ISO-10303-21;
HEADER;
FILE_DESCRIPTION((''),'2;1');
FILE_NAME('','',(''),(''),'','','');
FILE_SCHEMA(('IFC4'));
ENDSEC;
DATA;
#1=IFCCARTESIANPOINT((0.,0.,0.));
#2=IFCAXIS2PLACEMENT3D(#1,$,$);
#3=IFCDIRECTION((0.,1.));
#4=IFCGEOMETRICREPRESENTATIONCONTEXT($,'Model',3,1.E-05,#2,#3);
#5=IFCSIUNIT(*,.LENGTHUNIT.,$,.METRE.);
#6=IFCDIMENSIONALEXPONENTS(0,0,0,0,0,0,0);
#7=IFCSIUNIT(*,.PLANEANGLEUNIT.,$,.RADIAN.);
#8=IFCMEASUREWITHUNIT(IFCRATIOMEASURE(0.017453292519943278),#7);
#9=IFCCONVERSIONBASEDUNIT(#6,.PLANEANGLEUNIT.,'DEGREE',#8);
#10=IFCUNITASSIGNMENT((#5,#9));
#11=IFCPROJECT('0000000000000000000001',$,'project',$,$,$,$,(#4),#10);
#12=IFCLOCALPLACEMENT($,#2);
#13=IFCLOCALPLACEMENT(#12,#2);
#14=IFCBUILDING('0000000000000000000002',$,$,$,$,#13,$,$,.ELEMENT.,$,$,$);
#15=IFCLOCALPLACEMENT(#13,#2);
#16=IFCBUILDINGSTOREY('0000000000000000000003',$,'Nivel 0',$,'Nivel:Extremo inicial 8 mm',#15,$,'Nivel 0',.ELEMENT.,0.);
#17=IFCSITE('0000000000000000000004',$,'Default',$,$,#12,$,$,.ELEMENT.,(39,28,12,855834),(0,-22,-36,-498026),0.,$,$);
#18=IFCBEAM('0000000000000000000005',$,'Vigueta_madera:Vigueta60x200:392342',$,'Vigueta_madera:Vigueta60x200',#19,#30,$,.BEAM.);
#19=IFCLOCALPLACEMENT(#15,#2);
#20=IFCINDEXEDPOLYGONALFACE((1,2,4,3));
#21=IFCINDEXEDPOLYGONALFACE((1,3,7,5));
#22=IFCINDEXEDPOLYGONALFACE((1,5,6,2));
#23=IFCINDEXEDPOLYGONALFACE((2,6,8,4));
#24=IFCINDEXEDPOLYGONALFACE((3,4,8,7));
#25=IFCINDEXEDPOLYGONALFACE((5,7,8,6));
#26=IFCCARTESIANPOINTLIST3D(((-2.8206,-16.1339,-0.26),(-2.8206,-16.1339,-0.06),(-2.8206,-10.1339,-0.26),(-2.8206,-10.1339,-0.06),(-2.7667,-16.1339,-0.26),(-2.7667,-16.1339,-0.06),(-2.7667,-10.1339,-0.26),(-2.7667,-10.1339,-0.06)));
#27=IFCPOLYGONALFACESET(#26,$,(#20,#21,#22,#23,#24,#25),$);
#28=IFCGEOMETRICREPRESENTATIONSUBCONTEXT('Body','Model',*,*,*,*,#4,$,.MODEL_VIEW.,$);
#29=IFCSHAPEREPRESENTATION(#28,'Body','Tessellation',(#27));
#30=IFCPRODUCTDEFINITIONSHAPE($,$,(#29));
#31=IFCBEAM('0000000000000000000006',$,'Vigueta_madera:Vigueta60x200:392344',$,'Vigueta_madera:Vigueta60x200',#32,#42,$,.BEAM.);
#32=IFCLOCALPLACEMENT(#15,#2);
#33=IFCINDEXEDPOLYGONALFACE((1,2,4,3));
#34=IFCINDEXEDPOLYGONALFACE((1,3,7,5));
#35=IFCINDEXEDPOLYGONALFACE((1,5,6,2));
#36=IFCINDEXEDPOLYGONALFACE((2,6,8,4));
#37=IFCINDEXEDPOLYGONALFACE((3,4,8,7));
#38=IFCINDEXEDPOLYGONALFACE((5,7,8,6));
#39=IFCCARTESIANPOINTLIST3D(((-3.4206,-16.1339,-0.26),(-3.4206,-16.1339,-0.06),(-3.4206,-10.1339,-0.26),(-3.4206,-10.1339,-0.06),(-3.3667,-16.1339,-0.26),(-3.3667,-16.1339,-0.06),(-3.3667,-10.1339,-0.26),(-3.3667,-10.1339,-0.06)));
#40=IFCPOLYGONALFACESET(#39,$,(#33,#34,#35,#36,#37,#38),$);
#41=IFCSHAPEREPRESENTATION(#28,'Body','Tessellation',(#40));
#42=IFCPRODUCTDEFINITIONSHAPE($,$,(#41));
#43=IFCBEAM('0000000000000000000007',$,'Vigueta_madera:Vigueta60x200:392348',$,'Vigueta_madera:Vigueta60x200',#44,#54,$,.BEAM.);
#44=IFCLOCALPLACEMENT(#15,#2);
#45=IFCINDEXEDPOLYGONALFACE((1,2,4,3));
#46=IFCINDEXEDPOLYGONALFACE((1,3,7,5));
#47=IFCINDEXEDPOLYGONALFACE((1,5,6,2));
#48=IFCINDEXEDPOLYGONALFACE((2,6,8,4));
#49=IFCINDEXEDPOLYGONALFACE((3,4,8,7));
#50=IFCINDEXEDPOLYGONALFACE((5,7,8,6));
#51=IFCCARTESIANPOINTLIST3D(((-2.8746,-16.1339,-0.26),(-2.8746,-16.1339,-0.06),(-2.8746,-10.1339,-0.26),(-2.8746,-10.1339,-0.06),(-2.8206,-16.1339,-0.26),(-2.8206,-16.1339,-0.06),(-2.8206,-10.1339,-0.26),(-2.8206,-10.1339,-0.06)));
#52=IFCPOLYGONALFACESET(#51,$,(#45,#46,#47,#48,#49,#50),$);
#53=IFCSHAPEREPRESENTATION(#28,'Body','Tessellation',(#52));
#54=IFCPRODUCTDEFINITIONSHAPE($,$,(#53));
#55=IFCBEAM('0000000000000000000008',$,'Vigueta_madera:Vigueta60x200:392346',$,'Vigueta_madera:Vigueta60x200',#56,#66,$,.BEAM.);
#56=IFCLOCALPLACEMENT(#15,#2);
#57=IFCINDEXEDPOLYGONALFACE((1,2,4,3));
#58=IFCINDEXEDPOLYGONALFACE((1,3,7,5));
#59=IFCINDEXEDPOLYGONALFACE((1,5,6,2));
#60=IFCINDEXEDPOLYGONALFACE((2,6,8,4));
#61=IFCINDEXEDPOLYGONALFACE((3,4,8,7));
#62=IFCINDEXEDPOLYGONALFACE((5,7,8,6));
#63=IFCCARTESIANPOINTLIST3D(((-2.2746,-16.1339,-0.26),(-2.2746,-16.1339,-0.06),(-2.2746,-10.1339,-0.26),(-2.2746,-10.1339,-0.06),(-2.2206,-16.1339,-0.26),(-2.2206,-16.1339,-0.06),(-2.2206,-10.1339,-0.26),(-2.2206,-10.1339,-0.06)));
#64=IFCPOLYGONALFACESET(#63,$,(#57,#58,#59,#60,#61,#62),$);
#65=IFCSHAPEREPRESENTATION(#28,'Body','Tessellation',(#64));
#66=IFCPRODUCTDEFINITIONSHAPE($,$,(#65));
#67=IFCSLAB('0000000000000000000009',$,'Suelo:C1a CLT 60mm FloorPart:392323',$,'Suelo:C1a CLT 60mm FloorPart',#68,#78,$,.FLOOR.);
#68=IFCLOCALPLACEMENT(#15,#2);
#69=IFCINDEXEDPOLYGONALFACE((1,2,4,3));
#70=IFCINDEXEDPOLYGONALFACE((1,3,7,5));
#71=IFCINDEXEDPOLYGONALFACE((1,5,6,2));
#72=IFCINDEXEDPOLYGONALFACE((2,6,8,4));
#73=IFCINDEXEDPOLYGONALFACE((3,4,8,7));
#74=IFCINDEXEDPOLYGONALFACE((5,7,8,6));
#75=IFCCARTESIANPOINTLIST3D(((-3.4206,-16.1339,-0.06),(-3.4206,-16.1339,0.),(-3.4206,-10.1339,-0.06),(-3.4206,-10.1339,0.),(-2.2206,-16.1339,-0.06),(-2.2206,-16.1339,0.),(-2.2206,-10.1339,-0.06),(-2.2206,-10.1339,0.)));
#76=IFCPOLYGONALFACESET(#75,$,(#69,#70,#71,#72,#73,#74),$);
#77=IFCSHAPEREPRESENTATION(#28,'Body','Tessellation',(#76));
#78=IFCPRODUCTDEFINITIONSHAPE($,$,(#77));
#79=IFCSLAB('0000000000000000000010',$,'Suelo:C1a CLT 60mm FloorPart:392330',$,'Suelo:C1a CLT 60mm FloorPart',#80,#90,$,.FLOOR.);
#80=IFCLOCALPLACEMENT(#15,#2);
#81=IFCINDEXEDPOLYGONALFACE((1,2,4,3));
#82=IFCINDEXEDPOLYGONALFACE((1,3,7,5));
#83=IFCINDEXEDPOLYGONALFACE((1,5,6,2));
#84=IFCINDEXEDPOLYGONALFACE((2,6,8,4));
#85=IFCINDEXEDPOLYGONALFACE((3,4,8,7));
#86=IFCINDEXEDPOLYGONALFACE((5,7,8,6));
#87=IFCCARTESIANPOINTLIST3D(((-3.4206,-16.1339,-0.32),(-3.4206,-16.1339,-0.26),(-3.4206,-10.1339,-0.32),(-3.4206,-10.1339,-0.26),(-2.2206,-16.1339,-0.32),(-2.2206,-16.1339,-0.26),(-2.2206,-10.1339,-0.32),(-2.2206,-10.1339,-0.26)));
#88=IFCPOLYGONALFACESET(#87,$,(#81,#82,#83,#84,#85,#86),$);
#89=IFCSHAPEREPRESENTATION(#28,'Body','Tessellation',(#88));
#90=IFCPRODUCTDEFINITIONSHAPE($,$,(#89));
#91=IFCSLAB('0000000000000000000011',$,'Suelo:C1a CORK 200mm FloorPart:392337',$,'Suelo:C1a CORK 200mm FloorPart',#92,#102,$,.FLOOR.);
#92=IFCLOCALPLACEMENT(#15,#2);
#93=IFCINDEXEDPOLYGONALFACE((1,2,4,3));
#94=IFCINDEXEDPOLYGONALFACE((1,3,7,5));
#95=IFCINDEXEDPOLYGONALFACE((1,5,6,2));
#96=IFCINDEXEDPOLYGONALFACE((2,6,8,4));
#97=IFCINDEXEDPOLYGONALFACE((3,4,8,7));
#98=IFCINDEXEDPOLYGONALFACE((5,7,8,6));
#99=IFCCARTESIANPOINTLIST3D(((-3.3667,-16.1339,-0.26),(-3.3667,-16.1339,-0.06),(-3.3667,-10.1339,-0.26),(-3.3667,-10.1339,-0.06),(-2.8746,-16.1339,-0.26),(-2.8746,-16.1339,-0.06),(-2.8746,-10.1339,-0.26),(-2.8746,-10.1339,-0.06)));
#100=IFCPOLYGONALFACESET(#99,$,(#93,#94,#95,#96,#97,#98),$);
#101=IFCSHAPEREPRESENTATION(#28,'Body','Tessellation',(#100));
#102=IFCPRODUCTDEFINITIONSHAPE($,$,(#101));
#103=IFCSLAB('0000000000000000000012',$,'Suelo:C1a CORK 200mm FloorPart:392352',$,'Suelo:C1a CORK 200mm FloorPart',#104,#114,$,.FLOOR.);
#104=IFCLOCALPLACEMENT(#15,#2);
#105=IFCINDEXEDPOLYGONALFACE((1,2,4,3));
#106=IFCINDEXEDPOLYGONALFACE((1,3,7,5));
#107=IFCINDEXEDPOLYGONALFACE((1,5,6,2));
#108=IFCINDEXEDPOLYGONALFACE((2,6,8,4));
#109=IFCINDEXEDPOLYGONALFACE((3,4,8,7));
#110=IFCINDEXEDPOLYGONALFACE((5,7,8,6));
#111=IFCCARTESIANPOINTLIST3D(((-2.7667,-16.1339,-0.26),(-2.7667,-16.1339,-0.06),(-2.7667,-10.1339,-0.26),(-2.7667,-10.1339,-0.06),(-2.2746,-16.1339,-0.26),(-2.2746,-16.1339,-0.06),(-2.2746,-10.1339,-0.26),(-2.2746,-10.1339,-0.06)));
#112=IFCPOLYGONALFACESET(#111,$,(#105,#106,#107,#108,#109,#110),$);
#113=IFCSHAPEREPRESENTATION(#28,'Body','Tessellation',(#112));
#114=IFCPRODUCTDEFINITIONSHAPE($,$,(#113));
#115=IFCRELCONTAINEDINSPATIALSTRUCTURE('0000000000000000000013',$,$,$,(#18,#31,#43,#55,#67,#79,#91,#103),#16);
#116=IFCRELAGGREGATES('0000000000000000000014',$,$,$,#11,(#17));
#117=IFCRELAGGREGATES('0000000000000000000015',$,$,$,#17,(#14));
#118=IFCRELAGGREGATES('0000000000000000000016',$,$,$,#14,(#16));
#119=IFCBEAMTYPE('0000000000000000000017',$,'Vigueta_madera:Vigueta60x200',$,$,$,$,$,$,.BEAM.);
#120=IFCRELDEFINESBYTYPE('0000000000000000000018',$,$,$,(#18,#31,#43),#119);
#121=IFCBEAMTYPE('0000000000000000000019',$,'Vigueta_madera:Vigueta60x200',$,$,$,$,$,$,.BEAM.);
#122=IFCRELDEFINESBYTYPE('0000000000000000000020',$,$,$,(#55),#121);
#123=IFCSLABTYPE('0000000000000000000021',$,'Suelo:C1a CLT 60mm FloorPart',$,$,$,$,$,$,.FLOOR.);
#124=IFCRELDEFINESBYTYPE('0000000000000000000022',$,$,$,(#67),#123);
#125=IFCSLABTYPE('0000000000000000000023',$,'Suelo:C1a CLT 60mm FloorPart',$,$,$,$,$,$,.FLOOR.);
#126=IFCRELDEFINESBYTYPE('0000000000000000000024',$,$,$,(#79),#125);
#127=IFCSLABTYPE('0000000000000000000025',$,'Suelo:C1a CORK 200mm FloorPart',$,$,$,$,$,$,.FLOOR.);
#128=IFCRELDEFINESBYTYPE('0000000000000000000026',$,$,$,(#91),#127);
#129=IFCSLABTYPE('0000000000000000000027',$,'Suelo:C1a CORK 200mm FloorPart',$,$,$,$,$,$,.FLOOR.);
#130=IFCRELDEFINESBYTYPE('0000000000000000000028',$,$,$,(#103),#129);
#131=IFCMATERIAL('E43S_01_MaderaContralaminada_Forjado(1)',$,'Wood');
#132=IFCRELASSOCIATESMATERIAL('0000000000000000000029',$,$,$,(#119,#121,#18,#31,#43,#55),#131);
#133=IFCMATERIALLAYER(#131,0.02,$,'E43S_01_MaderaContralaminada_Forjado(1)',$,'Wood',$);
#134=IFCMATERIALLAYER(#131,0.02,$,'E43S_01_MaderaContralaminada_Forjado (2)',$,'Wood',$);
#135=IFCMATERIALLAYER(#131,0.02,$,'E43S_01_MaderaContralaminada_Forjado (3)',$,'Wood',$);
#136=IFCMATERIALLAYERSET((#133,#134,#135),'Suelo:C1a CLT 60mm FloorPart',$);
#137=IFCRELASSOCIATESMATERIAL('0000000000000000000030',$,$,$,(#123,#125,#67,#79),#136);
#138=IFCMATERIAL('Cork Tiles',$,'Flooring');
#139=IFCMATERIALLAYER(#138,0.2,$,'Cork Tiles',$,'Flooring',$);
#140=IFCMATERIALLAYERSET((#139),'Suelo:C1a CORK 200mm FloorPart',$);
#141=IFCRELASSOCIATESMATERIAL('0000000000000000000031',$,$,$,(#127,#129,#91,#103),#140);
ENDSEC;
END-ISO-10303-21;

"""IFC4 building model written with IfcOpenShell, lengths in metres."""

from ifc_helpers import new_model, entity, si_unit, converted_unit, direction, frame, frame_2d, origin, origin_2d_with_axis, place, context, subcontext, project, spatial, polyline, segment, composite_curve, rectangle, outline, extrude, source, transform, mapped, material, layer, layer_set, layer_usage, material_profile, profile_set, profile_usage, type_object, type_shapes, element, save


model = new_model("IFC4")

# Units and contexts
model_context = context("Model", 3, precision=1e-05, world=origin(), true_north=direction((0.0, 1.0)))
body_context = subcontext(model_context, "Body", "Model", "MODEL_VIEW")
ifc_project = project(units=[si_unit("LENGTHUNIT", "METRE"), converted_unit("PLANEANGLEUNIT", "DEGREE", entity("IfcRatioMeasure", 0.017453292519943278), si_unit("PLANEANGLEUNIT", "RADIAN"), dimensions=[0, 0, 0, 0, 0, 0, 0])], contexts=[model_context])

# Site, building, storey
site_placement = place(None, origin())
site = spatial("IfcSite", under=ifc_project, at=site_placement, Name="Default", CompositionType="ELEMENT", RefLatitude=(39, 28, 12, 855834), RefLongitude=(0, -22, -36, -498026), RefElevation=0.0)
building_placement = place(site_placement, origin())
building = spatial("IfcBuilding", under=site, at=building_placement, CompositionType="ELEMENT")
storey_placement = place(building_placement, origin())
storey = spatial("IfcBuildingStorey", under=building, at=storey_placement, Name="Nivel 0", ObjectType="Nivel:Extremo inicial 8 mm", LongName="Nivel 0", CompositionType="ELEMENT", Elevation=0.0)

# Beams
ifc_material_1 = material(Name="E43S_01_MaderaContralaminada_Forjado(1)", Category="Wood")
ifc_material_profile_1 = material_profile(ifc_material_1, outline(composite_curve([segment(polyline([(-0.027, -0.1, 0.0), (-0.027, 0.1, 0.0)]), True, "CONTINUOUS"), segment(polyline([(-0.027, 0.1, 0.0), (0.027, 0.1, 0.0)]), True, "CONTINUOUS"), segment(polyline([(0.027, 0.1, 0.0), (0.027, -0.1, 0.0)]), True, "CONTINUOUS"), segment(polyline([(0.027, -0.1, 0.0), (-0.027, -0.1, 0.0)]), True, "CONTINUOUS")], self_intersect=False), kind="CURVE"), Name="Vigueta60x200")
ifc_material_profile_2 = material_profile(ifc_material_1, outline(composite_curve([segment(polyline([(3.0, 0.027, 0.1), (3.0, 0.027, -0.1)]), True, "CONTINUOUS"), segment(polyline([(3.0, 0.027, -0.1), (-3.0, 0.027, -0.1)]), True, "CONTINUOUS"), segment(polyline([(-3.0, 0.027, -0.1), (-3.0, 0.027, 0.1)]), True, "CONTINUOUS"), segment(polyline([(-3.0, 0.027, 0.1), (3.0, 0.027, 0.1)]), True, "CONTINUOUS")], self_intersect=False), kind="CURVE"), Name="Vigueta60x200")
ifc_profile_set = profile_set([ifc_material_profile_1, ifc_material_profile_2], Name="Vigueta60x200")
ifc_profile_usage_1 = profile_usage(ifc_profile_set, cardinal=8)
beam_type_1 = type_object("IfcBeamType", Name="Vigueta_madera:Vigueta60x200", PredefinedType="BEAM", material=ifc_profile_set)
shared_shape_1 = source(origin(), body_context, "Body", "SweptSolid", [
    extrude(rectangle(XDim=0.2, YDim=0.054, at=origin_2d_with_axis()), frame((-3.0, 0.0, 0.0), z_axis=(1.0, 0.0, 0.0), x_axis=(0.0, 0.0, -1.0)), (0.0, 0.0, 1.0), 6.0),
])
type_shapes(beam_type_1, [shared_shape_1])
beam_1_placement = place(storey_placement, frame((-2.7936, -13.1339, -0.16), z_axis=(0.0, 0.0, 1.0), x_axis=(0.0, 1.0, 0.0)))
element("IfcBeam", 1, at=beam_1_placement, inside=storey, type_object=beam_type_1, material=ifc_profile_usage_1, Name="Vigueta_madera:Vigueta60x200:392342", ObjectType="Vigueta_madera:Vigueta60x200", PredefinedType="BEAM", context=body_context, shape_type="MappedRepresentation", body=[
    mapped(shared_shape_1, transform((0.0, 0.0, 0.0), scale=1.0)),
])
ifc_profile_usage_2 = profile_usage(ifc_profile_set, cardinal=8)
beam_2_placement = place(storey_placement, frame((-3.3936, -13.1339, -0.16), z_axis=(0.0, 0.0, 1.0), x_axis=(0.0, 1.0, 0.0)))
element("IfcBeam", 2, at=beam_2_placement, inside=storey, type_object=beam_type_1, material=ifc_profile_usage_2, Name="Vigueta_madera:Vigueta60x200:392344", ObjectType="Vigueta_madera:Vigueta60x200", PredefinedType="BEAM", context=body_context, shape_type="MappedRepresentation", body=[
    mapped(shared_shape_1, transform((0.0, 0.0, 0.0), scale=1.0)),
])
ifc_profile_usage_3 = profile_usage(ifc_profile_set, cardinal=8)
beam_3_placement = place(storey_placement, frame((-2.8476, -13.1339, -0.16), z_axis=(0.0, 0.0, 1.0), x_axis=(0.0, 1.0, 0.0)))
element("IfcBeam", 3, at=beam_3_placement, inside=storey, type_object=beam_type_1, material=ifc_profile_usage_3, Name="Vigueta_madera:Vigueta60x200:392348", ObjectType="Vigueta_madera:Vigueta60x200", PredefinedType="BEAM", context=body_context, shape_type="MappedRepresentation", body=[
    mapped(shared_shape_1, transform((0.0, 0.0, 0.0), scale=1.0)),
])
ifc_profile_usage_4 = profile_usage(ifc_profile_set, cardinal=8)
beam_type_2 = type_object("IfcBeamType", Name="Vigueta_madera:Vigueta60x200", PredefinedType="BEAM", material=ifc_profile_set)
shared_shape_2 = source(origin(), body_context, "Body", "SweptSolid", [
    extrude(rectangle(XDim=0.2, YDim=0.054, at=origin_2d_with_axis()), frame((-3.06, 0.0, 0.0), z_axis=(1.0, 0.0, 0.0), x_axis=(0.0, 0.0, -1.0)), (0.0, 0.0, 1.0), 6.0),
])
type_shapes(beam_type_2, [shared_shape_2])
beam_4_placement = place(storey_placement, frame((-2.2476, -13.0739, -0.16), z_axis=(0.0, 0.0, 1.0), x_axis=(0.0, 1.0, 0.0)))
element("IfcBeam", 4, at=beam_4_placement, inside=storey, type_object=beam_type_2, material=ifc_profile_usage_4, Name="Vigueta_madera:Vigueta60x200:392346", ObjectType="Vigueta_madera:Vigueta60x200", PredefinedType="BEAM", context=body_context, shape_type="MappedRepresentation", body=[
    mapped(shared_shape_2, transform((0.0, 0.0, 0.0), scale=1.0)),
])

# Slabs
ifc_layer_1 = layer(ifc_material_1, 0.02, Name="E43S_01_MaderaContralaminada_Forjado(1)", Category="Wood")
ifc_layer_2 = layer(ifc_material_1, 0.02, Name="E43S_01_MaderaContralaminada_Forjado (2)", Category="Wood")
ifc_layer_3 = layer(ifc_material_1, 0.02, Name="E43S_01_MaderaContralaminada_Forjado (3)", Category="Wood")
ifc_layer_set_1 = layer_set([ifc_layer_1, ifc_layer_2, ifc_layer_3], Name="Suelo:C1a CLT 60mm FloorPart")
ifc_layer_usage_1 = layer_usage(ifc_layer_set_1, "AXIS3", "POSITIVE", 0.0)
slab_type_1 = type_object("IfcSlabType", Name="Suelo:C1a CLT 60mm FloorPart", PredefinedType="FLOOR", material=ifc_layer_set_1)
slab_1_placement = place(storey_placement, origin())
element("IfcSlab", 5, at=slab_1_placement, inside=storey, type_object=slab_type_1, material=ifc_layer_usage_1, Name="Suelo:C1a CLT 60mm FloorPart:392323", ObjectType="Suelo:C1a CLT 60mm FloorPart", PredefinedType="FLOOR", context=body_context, shape_type="SweptSolid", body=[
    extrude(rectangle(XDim=6.0, YDim=1.2, at=frame_2d((0.0, 0.0), x_axis=(1.0, 0.0))), frame((-2.8206, -13.1339, 0.0), z_axis=(0.0, 0.0, -1.0), x_axis=(0.0, 1.0, 0.0)), (0.0, 0.0, 1.0), 0.06),
])
ifc_layer_usage_2 = layer_usage(ifc_layer_set_1, "AXIS3", "POSITIVE", 0.0)
slab_type_2 = type_object("IfcSlabType", Name="Suelo:C1a CLT 60mm FloorPart", PredefinedType="FLOOR", material=ifc_layer_set_1)
slab_2_placement = place(storey_placement, origin())
element("IfcSlab", 6, at=slab_2_placement, inside=storey, type_object=slab_type_2, material=ifc_layer_usage_2, Name="Suelo:C1a CLT 60mm FloorPart:392330", ObjectType="Suelo:C1a CLT 60mm FloorPart", PredefinedType="FLOOR", context=body_context, shape_type="SweptSolid", body=[
    extrude(rectangle(XDim=6.0, YDim=1.2, at=frame_2d((0.0, 0.0), x_axis=(1.0, 0.0))), frame((-2.8206, -13.1339, -0.26), z_axis=(0.0, 0.0, -1.0), x_axis=(0.0, 1.0, 0.0)), (0.0, 0.0, 1.0), 0.06),
])
ifc_material_2 = material(Name="Cork Tiles", Category="Flooring")
ifc_layer_4 = layer(ifc_material_2, 0.2, Name="Cork Tiles", Category="Flooring")
ifc_layer_set_2 = layer_set([ifc_layer_4], Name="Suelo:C1a CORK 200mm FloorPart")
ifc_layer_usage_3 = layer_usage(ifc_layer_set_2, "AXIS3", "POSITIVE", 0.0)
slab_type_3 = type_object("IfcSlabType", Name="Suelo:C1a CORK 200mm FloorPart", PredefinedType="FLOOR", material=ifc_layer_set_2)
slab_3_placement = place(storey_placement, origin())
element("IfcSlab", 7, at=slab_3_placement, inside=storey, type_object=slab_type_3, material=ifc_layer_usage_3, Name="Suelo:C1a CORK 200mm FloorPart:392337", ObjectType="Suelo:C1a CORK 200mm FloorPart", PredefinedType="FLOOR", context=body_context, shape_type="SweptSolid", body=[
    extrude(rectangle(XDim=6.0, YDim=0.492, at=frame_2d((0.0, 0.0), x_axis=(1.0, 0.0))), frame((-3.1206, -13.1339, -0.06), z_axis=(0.0, 0.0, -1.0), x_axis=(0.0, 1.0, 0.0)), (0.0, 0.0, 1.0), 0.2),
])
ifc_layer_usage_4 = layer_usage(ifc_layer_set_2, "AXIS3", "POSITIVE", 0.0)
slab_type_4 = type_object("IfcSlabType", Name="Suelo:C1a CORK 200mm FloorPart", PredefinedType="FLOOR", material=ifc_layer_set_2)
slab_4_placement = place(storey_placement, origin())
element("IfcSlab", 8, at=slab_4_placement, inside=storey, type_object=slab_type_4, material=ifc_layer_usage_4, Name="Suelo:C1a CORK 200mm FloorPart:392352", ObjectType="Suelo:C1a CORK 200mm FloorPart", PredefinedType="FLOOR", context=body_context, shape_type="SweptSolid", body=[
    extrude(rectangle(XDim=6.0, YDim=0.492, at=frame_2d((0.0, 0.0), x_axis=(1.0, 0.0))), frame((-2.5206, -13.1339, -0.06), z_axis=(0.0, 0.0, -1.0), x_axis=(0.0, 1.0, 0.0)), (0.0, 0.0, 1.0), 0.2),
])

save(model, "model.ifc")
